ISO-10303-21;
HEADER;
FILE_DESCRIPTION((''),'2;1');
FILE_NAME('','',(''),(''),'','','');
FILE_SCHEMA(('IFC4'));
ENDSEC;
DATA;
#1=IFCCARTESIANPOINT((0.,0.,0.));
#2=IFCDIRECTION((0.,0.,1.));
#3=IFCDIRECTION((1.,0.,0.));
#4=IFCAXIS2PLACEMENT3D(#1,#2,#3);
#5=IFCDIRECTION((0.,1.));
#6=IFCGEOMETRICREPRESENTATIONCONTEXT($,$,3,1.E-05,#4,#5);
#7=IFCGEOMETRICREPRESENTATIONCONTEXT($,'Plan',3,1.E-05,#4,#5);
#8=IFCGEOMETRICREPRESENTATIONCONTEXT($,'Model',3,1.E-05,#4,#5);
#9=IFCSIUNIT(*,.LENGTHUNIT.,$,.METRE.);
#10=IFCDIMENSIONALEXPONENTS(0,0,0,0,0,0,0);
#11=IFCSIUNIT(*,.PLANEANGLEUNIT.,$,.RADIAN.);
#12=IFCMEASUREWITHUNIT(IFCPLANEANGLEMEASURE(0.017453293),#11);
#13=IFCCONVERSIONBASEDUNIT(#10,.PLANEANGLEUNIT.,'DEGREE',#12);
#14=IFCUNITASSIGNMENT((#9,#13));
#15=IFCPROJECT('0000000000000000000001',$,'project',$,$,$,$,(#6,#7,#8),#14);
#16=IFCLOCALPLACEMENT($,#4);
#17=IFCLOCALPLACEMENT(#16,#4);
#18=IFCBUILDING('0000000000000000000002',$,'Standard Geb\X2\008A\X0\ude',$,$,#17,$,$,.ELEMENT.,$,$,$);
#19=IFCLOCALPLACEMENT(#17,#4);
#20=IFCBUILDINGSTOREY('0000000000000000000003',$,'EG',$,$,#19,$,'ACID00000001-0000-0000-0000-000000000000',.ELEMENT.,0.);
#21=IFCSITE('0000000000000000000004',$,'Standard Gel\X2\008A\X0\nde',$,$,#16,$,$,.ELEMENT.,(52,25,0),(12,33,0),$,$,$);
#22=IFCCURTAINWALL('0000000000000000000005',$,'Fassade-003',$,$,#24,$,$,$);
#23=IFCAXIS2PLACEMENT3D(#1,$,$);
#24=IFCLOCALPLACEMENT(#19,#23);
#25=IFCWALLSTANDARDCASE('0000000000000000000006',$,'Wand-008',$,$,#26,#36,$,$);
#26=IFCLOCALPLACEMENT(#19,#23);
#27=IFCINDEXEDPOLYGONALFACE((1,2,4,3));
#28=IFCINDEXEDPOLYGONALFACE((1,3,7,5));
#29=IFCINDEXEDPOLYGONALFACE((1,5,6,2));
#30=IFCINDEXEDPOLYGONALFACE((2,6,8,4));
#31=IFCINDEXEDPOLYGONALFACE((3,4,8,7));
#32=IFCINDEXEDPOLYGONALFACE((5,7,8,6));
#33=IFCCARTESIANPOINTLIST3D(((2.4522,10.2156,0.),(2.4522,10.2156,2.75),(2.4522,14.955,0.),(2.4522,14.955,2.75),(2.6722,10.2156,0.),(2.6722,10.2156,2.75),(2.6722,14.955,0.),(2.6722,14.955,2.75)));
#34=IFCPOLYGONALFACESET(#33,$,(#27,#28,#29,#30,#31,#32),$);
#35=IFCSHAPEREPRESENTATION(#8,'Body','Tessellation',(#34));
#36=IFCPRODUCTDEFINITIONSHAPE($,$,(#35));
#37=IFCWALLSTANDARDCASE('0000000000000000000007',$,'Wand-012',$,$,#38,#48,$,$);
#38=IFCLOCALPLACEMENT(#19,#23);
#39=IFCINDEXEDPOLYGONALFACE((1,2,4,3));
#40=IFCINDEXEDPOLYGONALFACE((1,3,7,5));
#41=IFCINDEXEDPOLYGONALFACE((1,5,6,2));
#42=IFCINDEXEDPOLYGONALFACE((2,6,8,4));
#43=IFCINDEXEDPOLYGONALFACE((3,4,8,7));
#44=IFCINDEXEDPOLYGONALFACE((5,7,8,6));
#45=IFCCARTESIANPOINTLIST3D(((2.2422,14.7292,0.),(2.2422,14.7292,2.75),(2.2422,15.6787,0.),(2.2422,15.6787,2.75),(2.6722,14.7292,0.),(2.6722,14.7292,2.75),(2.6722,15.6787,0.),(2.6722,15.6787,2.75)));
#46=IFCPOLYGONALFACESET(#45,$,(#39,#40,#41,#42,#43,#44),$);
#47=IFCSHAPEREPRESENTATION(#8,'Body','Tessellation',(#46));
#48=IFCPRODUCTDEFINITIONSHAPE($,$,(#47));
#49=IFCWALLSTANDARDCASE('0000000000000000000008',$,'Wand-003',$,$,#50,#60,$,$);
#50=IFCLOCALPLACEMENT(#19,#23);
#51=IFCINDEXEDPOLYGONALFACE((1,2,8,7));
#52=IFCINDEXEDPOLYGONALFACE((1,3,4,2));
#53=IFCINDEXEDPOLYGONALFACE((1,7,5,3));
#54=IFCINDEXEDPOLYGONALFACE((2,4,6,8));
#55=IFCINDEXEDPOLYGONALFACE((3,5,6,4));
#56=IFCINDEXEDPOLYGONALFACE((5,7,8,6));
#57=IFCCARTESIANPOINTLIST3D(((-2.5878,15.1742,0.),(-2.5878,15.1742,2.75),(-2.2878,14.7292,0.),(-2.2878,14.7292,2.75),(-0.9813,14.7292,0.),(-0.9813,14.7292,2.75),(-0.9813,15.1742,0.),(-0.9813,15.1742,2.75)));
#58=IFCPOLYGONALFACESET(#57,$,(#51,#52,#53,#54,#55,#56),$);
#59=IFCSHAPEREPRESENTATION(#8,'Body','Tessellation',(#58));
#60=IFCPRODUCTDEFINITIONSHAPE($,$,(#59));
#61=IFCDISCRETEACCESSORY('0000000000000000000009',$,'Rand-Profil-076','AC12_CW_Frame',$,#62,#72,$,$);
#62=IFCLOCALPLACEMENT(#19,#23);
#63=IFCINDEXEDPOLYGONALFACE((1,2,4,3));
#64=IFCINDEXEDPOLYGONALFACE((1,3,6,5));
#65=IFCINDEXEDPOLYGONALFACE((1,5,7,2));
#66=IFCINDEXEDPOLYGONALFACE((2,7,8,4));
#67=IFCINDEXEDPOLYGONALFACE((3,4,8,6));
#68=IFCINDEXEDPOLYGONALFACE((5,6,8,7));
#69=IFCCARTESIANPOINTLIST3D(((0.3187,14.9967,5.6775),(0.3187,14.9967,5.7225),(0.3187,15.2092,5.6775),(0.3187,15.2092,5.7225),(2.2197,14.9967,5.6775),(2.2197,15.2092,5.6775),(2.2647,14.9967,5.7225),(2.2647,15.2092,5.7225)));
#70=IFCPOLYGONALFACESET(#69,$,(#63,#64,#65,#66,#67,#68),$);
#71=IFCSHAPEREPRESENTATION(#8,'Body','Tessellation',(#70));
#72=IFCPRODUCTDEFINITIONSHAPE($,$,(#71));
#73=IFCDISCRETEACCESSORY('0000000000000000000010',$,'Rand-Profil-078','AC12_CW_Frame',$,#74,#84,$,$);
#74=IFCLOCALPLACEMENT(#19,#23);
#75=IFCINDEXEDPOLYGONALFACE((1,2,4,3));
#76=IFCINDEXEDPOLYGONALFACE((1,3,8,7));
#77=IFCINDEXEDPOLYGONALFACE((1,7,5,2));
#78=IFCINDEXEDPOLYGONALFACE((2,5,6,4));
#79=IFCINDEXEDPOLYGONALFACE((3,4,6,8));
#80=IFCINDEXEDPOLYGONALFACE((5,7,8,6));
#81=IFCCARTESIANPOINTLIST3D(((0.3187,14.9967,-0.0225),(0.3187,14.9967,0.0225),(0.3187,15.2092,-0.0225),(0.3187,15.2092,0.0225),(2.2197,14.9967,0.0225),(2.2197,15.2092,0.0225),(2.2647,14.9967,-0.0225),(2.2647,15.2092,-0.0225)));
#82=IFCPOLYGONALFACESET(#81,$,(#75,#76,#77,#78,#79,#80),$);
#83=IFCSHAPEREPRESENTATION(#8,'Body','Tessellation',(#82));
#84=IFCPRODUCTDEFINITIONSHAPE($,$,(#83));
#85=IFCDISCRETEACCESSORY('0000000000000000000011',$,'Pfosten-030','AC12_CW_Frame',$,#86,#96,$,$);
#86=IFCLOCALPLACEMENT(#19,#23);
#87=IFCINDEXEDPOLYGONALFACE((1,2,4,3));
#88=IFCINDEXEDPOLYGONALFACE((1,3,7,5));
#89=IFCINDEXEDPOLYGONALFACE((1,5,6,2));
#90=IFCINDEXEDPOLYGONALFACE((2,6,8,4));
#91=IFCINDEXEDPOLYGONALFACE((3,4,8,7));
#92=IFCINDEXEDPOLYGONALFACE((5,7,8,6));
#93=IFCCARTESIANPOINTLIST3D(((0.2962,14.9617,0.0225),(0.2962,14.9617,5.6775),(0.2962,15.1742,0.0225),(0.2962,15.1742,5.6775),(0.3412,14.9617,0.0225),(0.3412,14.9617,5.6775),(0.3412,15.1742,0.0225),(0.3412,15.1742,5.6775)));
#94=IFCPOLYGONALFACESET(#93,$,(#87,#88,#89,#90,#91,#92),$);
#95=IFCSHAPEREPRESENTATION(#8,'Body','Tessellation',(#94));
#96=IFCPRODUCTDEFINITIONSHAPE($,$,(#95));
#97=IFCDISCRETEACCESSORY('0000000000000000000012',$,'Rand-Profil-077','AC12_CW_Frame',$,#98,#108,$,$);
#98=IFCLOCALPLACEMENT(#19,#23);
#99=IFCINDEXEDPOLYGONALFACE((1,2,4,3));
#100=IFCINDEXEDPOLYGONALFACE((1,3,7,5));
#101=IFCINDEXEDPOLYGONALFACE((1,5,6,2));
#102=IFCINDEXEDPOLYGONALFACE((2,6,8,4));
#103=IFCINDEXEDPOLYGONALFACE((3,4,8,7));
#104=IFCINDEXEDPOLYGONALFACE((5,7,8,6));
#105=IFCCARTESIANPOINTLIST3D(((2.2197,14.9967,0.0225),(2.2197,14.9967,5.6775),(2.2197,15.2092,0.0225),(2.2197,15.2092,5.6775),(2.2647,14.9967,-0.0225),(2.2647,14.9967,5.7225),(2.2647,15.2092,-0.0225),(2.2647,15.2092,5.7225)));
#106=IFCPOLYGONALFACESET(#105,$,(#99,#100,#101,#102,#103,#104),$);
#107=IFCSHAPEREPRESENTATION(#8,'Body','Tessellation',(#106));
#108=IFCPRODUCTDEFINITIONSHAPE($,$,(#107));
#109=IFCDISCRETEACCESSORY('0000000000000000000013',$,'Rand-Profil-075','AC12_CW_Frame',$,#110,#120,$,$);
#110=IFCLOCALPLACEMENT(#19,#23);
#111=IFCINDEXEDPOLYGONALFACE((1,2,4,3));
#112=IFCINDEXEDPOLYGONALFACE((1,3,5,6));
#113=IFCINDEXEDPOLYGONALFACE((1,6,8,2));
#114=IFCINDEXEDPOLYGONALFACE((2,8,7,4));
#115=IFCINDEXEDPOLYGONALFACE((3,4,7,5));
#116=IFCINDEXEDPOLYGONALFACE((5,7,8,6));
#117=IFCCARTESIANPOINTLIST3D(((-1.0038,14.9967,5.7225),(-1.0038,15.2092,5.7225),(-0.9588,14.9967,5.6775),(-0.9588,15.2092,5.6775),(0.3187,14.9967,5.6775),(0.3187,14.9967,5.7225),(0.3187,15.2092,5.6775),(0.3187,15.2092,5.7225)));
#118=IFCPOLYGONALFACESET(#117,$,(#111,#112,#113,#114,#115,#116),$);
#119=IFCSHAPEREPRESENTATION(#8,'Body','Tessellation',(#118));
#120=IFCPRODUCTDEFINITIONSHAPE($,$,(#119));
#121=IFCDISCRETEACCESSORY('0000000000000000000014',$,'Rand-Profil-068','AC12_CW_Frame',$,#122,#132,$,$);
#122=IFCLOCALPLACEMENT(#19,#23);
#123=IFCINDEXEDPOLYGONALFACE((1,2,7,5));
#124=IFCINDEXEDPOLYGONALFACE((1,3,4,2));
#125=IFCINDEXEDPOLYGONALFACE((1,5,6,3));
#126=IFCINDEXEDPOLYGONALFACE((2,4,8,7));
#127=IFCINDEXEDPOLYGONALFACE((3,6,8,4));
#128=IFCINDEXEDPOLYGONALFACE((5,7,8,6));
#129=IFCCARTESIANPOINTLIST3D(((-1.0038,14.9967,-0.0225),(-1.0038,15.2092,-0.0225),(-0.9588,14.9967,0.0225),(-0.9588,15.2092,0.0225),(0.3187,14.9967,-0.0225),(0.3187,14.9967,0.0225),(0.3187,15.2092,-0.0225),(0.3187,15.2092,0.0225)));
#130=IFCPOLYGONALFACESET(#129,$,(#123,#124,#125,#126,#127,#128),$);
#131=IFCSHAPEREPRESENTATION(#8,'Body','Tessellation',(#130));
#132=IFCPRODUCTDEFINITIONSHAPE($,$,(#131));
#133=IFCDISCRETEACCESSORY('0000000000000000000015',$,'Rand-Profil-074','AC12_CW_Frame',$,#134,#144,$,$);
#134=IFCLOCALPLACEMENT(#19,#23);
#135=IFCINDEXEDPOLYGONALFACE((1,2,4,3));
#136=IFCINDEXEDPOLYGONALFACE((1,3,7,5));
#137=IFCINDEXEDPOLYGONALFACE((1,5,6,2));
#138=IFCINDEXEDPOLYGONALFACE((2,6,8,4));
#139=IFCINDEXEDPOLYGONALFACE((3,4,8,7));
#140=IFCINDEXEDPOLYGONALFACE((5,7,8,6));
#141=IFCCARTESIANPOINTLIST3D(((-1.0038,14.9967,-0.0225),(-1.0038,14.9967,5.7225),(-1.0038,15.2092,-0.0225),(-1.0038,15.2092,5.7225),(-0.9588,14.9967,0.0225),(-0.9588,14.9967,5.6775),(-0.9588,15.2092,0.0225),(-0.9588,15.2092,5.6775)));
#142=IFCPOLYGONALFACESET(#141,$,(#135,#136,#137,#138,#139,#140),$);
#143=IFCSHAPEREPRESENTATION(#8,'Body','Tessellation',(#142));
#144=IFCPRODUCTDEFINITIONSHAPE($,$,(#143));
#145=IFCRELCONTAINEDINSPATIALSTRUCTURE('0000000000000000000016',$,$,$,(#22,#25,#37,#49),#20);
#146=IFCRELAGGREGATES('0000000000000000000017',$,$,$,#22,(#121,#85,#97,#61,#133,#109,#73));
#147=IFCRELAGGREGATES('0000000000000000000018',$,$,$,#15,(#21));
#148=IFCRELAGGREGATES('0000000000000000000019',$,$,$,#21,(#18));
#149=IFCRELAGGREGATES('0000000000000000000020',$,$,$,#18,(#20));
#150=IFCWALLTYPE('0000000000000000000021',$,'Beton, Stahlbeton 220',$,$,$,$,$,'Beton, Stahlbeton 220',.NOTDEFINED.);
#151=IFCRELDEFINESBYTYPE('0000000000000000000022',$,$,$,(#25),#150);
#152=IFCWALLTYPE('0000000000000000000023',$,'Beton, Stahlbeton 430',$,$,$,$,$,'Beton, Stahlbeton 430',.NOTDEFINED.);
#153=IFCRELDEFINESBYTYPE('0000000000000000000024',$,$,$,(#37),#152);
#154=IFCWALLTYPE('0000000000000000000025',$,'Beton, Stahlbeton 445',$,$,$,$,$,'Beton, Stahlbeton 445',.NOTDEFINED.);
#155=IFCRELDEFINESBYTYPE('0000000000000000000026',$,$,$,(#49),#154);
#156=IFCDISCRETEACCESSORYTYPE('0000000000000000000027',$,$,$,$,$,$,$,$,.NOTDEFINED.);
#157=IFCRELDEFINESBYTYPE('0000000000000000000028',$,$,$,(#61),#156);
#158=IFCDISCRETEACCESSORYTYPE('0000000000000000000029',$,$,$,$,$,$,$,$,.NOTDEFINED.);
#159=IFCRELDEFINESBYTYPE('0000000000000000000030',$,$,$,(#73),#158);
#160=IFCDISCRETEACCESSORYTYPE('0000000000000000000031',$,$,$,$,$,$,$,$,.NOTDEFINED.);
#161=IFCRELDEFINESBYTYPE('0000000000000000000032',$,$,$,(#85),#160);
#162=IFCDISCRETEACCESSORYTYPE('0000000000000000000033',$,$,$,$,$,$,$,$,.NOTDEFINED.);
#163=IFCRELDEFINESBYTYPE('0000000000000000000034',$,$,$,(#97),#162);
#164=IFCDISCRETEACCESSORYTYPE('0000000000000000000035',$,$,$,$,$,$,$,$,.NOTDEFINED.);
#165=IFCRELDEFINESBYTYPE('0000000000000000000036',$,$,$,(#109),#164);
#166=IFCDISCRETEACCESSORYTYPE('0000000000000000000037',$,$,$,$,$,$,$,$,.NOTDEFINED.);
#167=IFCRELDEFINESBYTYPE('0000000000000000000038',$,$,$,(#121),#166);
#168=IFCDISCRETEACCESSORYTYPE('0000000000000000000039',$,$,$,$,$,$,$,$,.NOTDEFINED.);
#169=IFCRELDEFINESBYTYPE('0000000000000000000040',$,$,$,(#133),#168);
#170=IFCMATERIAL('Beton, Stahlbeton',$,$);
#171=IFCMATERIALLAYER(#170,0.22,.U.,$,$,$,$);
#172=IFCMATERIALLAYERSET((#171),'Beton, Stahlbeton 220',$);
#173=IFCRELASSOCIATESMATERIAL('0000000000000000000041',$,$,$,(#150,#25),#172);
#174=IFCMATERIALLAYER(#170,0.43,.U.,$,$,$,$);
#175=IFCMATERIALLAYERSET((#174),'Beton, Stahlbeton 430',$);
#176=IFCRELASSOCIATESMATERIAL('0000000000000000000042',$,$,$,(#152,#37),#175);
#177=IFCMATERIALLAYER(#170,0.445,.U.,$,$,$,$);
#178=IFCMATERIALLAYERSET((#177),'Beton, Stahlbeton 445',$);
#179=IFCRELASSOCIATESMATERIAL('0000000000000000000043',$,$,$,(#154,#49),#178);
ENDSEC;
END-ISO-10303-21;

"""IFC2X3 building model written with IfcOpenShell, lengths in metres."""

from ifc_helpers import new_model, entity, si_unit, converted_unit, direction, frame, origin_with_axes, place, context, project, spatial, polyline, outline, extrude, source, transform, mapped, material, layer, layer_set, layer_usage, type_object, type_shapes, element, aggregate, save


model = new_model("IFC2X3")

# Units and contexts
model_context = context("Model", 3, precision=1e-05, world=origin_with_axes(), true_north=direction((0.0, 1.0)))
plan_context = context("Plan", 3, precision=1e-05, world=origin_with_axes(), true_north=direction((0.0, 1.0)))
context_of_model = context(None, 3, precision=1e-05, world=origin_with_axes(), true_north=direction((0.0, 1.0)))
ifc_project = project(units=[si_unit("LENGTHUNIT", "METRE"), converted_unit("PLANEANGLEUNIT", "DEGREE", entity("IfcPlaneAngleMeasure", 0.017453293), si_unit("PLANEANGLEUNIT", "RADIAN"), dimensions=[0, 0, 0, 0, 0, 0, 0])], contexts=[context_of_model, plan_context, model_context])

# Site, building, storey
site_placement = place(None, origin_with_axes())
site = spatial("IfcSite", under=ifc_project, at=site_placement, Name="Standard Gel\u008ande", CompositionType="ELEMENT", RefLatitude=(52, 25, 0), RefLongitude=(12, 33, 0))
building_placement = place(site_placement, origin_with_axes())
building = spatial("IfcBuilding", under=site, at=building_placement, Name="Standard Geb\u008aude", CompositionType="ELEMENT")
storey_placement = place(building_placement, origin_with_axes())
storey = spatial("IfcBuildingStorey", under=building, at=storey_placement, Name="EG", LongName="ACID00000001-0000-0000-0000-000000000000", CompositionType="ELEMENT", Elevation=0.0)

# Curtain wall
curtain_wall_placement = place(storey_placement, frame((-0.9813, 15.1742, 0.0), z_axis=(0.0, 0.0, 1.0), x_axis=(1.0, 0.0, 0.0)))
curtain_wall = element("IfcCurtainWall", 1, at=curtain_wall_placement, inside=storey, Name="Fassade-003")

# Shared definitions
ifc_material_1 = material(Name="Beton, Stahlbeton")

# Walls
ifc_layer_1 = layer(ifc_material_1, 0.22, ventilated="UNKNOWN")
ifc_layer_set_1 = layer_set([ifc_layer_1], Name="Beton, Stahlbeton 220")
ifc_layer_usage_1 = layer_usage(ifc_layer_set_1, "AXIS2", "NEGATIVE", 0.0)
wall_type_1 = type_object("IfcWallType", Name="Beton, Stahlbeton 220", ElementType="Beton, Stahlbeton 220", PredefinedType="NOTDEFINED", material=ifc_layer_set_1)
wall_1_placement = place(storey_placement, frame((2.6722, 14.955, 0.0), z_axis=(0.0, 0.0, 1.0), x_axis=(0.0, -1.0, 0.0)))
element("IfcWallStandardCase", 2, at=wall_1_placement, inside=storey, type_object=wall_type_1, material=ifc_layer_usage_1, Name="Wand-008", context=model_context, shape_type="SweptSolid", body=[
    extrude(outline(polyline([(0.0, -0.22), (4.7394, -0.22), (4.7394, 0.0), (0.0, 0.0), (0.0, -0.22)])), origin_with_axes(), (0.0, 0.0, 1.0), 2.75),
])
ifc_layer_2 = layer(ifc_material_1, 0.43, ventilated="UNKNOWN")
ifc_layer_set_2 = layer_set([ifc_layer_2], Name="Beton, Stahlbeton 430")
ifc_layer_usage_2 = layer_usage(ifc_layer_set_2, "AXIS2", "POSITIVE", 0.0)
wall_type_2 = type_object("IfcWallType", Name="Beton, Stahlbeton 430", ElementType="Beton, Stahlbeton 430", PredefinedType="NOTDEFINED", material=ifc_layer_set_2)
wall_2_placement = place(storey_placement, frame((2.6722, 14.7292, 0.0), z_axis=(0.0, 0.0, 1.0), x_axis=(0.0, 1.0, 0.0)))
element("IfcWallStandardCase", 3, at=wall_2_placement, inside=storey, type_object=wall_type_2, material=ifc_layer_usage_2, Name="Wand-012", context=model_context, shape_type="SweptSolid", body=[
    extrude(outline(polyline([(0.0, 0.0), (0.9495, 0.0), (0.9495, 0.43), (0.0, 0.43), (0.0, 0.0)])), origin_with_axes(), (0.0, 0.0, 1.0), 2.75),
])
ifc_layer_3 = layer(ifc_material_1, 0.445, ventilated="UNKNOWN")
ifc_layer_set_3 = layer_set([ifc_layer_3], Name="Beton, Stahlbeton 445")
ifc_layer_usage_3 = layer_usage(ifc_layer_set_3, "AXIS2", "NEGATIVE", 0.0)
wall_type_3 = type_object("IfcWallType", Name="Beton, Stahlbeton 445", ElementType="Beton, Stahlbeton 445", PredefinedType="NOTDEFINED", material=ifc_layer_set_3)
wall_3_placement = place(storey_placement, frame((-2.5878, 15.1742, 0.0), z_axis=(0.0, 0.0, 1.0), x_axis=(1.0, 0.0, 0.0)))
element("IfcWallStandardCase", 4, at=wall_3_placement, inside=storey, type_object=wall_type_3, material=ifc_layer_usage_3, Name="Wand-003", context=model_context, shape_type="SweptSolid", body=[
    extrude(outline(polyline([(0.3, -0.445), (1.6065, -0.445), (1.6065, 0.0), (0.0, 0.0), (0.3, -0.445)])), origin_with_axes(), (0.0, 0.0, 1.0), 2.75),
])

# Discrete accessories
discrete_accessory_type_1 = type_object("IfcDiscreteAccessoryType")
shared_shape_1 = source(origin_with_axes(), model_context, "Body", "SweptSolid", [
    extrude(outline(polyline([(0.0, 0.0), (1.901, 0.0), (1.946, -0.045), (0.0, -0.045), (0.0, 0.0)])), origin_with_axes(), (0.0, 0.0, 1.0), 0.2125),
])
type_shapes(discrete_accessory_type_1, [shared_shape_1])
discrete_accessory_1_placement = place(storey_placement, frame((0.3187, 14.9967, 5.6775), z_axis=(0.0, 1.0, 0.0), x_axis=(1.0, 0.0, 0.0)))
discrete_accessory_1 = element("IfcDiscreteAccessory", 5, at=discrete_accessory_1_placement, type_object=discrete_accessory_type_1, Name="Rand-Profil-076", Description="AC12_CW_Frame", context=model_context, shape_type="MappedRepresentation", body=[
    mapped(shared_shape_1, transform((0.0, 0.0, 0.0), scale=1.0)),
])
discrete_accessory_type_2 = type_object("IfcDiscreteAccessoryType")
shared_shape_2 = source(origin_with_axes(), model_context, "Body", "SweptSolid", [
    extrude(outline(polyline([(0.0, 0.0), (1.946, 0.0), (1.901, -0.045), (0.0, -0.045), (0.0, 0.0)])), origin_with_axes(), (0.0, 0.0, 1.0), 0.2125),
])
type_shapes(discrete_accessory_type_2, [shared_shape_2])
discrete_accessory_2_placement = place(storey_placement, frame((0.3187, 14.9967, -0.0225), z_axis=(0.0, 1.0, 0.0), x_axis=(1.0, 0.0, 0.0)))
discrete_accessory_2 = element("IfcDiscreteAccessory", 6, at=discrete_accessory_2_placement, type_object=discrete_accessory_type_2, Name="Rand-Profil-078", Description="AC12_CW_Frame", context=model_context, shape_type="MappedRepresentation", body=[
    mapped(shared_shape_2, transform((0.0, 0.0, 0.0), scale=1.0)),
])
discrete_accessory_type_3 = type_object("IfcDiscreteAccessoryType")
shared_shape_3 = source(origin_with_axes(), model_context, "Body", "SweptSolid", [
    extrude(outline(polyline([(0.0, 0.0), (5.655, 0.0), (5.655, -0.2125), (0.0, -0.2125), (0.0, 0.0)])), origin_with_axes(), (0.0, 0.0, 1.0), 0.045),
])
type_shapes(discrete_accessory_type_3, [shared_shape_3])
discrete_accessory_3_placement = place(storey_placement, frame((0.2962, 14.9617, 0.0225), z_axis=(1.0, 0.0, 0.0), x_axis=(0.0, 0.0, 1.0)))
discrete_accessory_3 = element("IfcDiscreteAccessory", 7, at=discrete_accessory_3_placement, type_object=discrete_accessory_type_3, Name="Pfosten-030", Description="AC12_CW_Frame", context=model_context, shape_type="MappedRepresentation", body=[
    mapped(shared_shape_3, transform((0.0, 0.0, 0.0), scale=1.0)),
])
discrete_accessory_type_4 = type_object("IfcDiscreteAccessoryType")
shared_shape_4 = source(origin_with_axes(), model_context, "Body", "SweptSolid", [
    extrude(outline(polyline([(0.0, 0.0), (5.745, 0.0), (5.7, -0.045), (0.045, -0.045), (0.0, 0.0)])), origin_with_axes(), (0.0, 0.0, 1.0), 0.2125),
])
type_shapes(discrete_accessory_type_4, [shared_shape_4])
discrete_accessory_4_placement = place(storey_placement, frame((2.2647, 14.9967, -0.0225), z_axis=(0.0, 1.0, 0.0), x_axis=(0.0, 0.0, 1.0)))
discrete_accessory_4 = element("IfcDiscreteAccessory", 8, at=discrete_accessory_4_placement, type_object=discrete_accessory_type_4, Name="Rand-Profil-077", Description="AC12_CW_Frame", context=model_context, shape_type="MappedRepresentation", body=[
    mapped(shared_shape_4, transform((0.0, 0.0, 0.0), scale=1.0)),
])
discrete_accessory_type_5 = type_object("IfcDiscreteAccessoryType")
shared_shape_5 = source(origin_with_axes(), model_context, "Body", "SweptSolid", [
    extrude(outline(polyline([(0.0, 0.0), (1.2775, 0.0), (1.2775, -0.045), (-0.045, -0.045), (0.0, 0.0)])), origin_with_axes(), (0.0, 0.0, 1.0), 0.2125),
])
type_shapes(discrete_accessory_type_5, [shared_shape_5])
discrete_accessory_5_placement = place(storey_placement, frame((-0.9588, 14.9967, 5.6775), z_axis=(0.0, 1.0, 0.0), x_axis=(1.0, 0.0, 0.0)))
discrete_accessory_5 = element("IfcDiscreteAccessory", 9, at=discrete_accessory_5_placement, type_object=discrete_accessory_type_5, Name="Rand-Profil-075", Description="AC12_CW_Frame", context=model_context, shape_type="MappedRepresentation", body=[
    mapped(shared_shape_5, transform((0.0, 0.0, 0.0), scale=1.0)),
])
discrete_accessory_type_6 = type_object("IfcDiscreteAccessoryType")
shared_shape_6 = source(origin_with_axes(), model_context, "Body", "SweptSolid", [
    extrude(outline(polyline([(0.0, 0.0), (1.3225, 0.0), (1.3225, -0.045), (0.045, -0.045), (0.0, 0.0)])), origin_with_axes(), (0.0, 0.0, 1.0), 0.2125),
])
type_shapes(discrete_accessory_type_6, [shared_shape_6])
discrete_accessory_6_placement = place(storey_placement, frame((-1.0038, 14.9967, -0.0225), z_axis=(0.0, 1.0, 0.0), x_axis=(1.0, 0.0, 0.0)))
discrete_accessory_6 = element("IfcDiscreteAccessory", 10, at=discrete_accessory_6_placement, type_object=discrete_accessory_type_6, Name="Rand-Profil-068", Description="AC12_CW_Frame", context=model_context, shape_type="MappedRepresentation", body=[
    mapped(shared_shape_6, transform((0.0, 0.0, 0.0), scale=1.0)),
])
discrete_accessory_type_7 = type_object("IfcDiscreteAccessoryType")
shared_shape_7 = source(origin_with_axes(), model_context, "Body", "SweptSolid", [
    extrude(outline(polyline([(0.0, 0.0), (5.655, 0.0), (5.7, -0.045), (-0.045, -0.045), (0.0, 0.0)])), origin_with_axes(), (0.0, 0.0, 1.0), 0.2125),
])
type_shapes(discrete_accessory_type_7, [shared_shape_7])
discrete_accessory_7_placement = place(storey_placement, frame((-0.9588, 14.9967, 0.0225), z_axis=(0.0, 1.0, 0.0), x_axis=(0.0, 0.0, 1.0)))
discrete_accessory_7 = element("IfcDiscreteAccessory", 11, at=discrete_accessory_7_placement, type_object=discrete_accessory_type_7, Name="Rand-Profil-074", Description="AC12_CW_Frame", context=model_context, shape_type="MappedRepresentation", body=[
    mapped(shared_shape_7, transform((0.0, 0.0, 0.0), scale=1.0)),
])
aggregate(curtain_wall, [discrete_accessory_6, discrete_accessory_3, discrete_accessory_4, discrete_accessory_1, discrete_accessory_7, discrete_accessory_5, discrete_accessory_2])

save(model, "model.ifc")
